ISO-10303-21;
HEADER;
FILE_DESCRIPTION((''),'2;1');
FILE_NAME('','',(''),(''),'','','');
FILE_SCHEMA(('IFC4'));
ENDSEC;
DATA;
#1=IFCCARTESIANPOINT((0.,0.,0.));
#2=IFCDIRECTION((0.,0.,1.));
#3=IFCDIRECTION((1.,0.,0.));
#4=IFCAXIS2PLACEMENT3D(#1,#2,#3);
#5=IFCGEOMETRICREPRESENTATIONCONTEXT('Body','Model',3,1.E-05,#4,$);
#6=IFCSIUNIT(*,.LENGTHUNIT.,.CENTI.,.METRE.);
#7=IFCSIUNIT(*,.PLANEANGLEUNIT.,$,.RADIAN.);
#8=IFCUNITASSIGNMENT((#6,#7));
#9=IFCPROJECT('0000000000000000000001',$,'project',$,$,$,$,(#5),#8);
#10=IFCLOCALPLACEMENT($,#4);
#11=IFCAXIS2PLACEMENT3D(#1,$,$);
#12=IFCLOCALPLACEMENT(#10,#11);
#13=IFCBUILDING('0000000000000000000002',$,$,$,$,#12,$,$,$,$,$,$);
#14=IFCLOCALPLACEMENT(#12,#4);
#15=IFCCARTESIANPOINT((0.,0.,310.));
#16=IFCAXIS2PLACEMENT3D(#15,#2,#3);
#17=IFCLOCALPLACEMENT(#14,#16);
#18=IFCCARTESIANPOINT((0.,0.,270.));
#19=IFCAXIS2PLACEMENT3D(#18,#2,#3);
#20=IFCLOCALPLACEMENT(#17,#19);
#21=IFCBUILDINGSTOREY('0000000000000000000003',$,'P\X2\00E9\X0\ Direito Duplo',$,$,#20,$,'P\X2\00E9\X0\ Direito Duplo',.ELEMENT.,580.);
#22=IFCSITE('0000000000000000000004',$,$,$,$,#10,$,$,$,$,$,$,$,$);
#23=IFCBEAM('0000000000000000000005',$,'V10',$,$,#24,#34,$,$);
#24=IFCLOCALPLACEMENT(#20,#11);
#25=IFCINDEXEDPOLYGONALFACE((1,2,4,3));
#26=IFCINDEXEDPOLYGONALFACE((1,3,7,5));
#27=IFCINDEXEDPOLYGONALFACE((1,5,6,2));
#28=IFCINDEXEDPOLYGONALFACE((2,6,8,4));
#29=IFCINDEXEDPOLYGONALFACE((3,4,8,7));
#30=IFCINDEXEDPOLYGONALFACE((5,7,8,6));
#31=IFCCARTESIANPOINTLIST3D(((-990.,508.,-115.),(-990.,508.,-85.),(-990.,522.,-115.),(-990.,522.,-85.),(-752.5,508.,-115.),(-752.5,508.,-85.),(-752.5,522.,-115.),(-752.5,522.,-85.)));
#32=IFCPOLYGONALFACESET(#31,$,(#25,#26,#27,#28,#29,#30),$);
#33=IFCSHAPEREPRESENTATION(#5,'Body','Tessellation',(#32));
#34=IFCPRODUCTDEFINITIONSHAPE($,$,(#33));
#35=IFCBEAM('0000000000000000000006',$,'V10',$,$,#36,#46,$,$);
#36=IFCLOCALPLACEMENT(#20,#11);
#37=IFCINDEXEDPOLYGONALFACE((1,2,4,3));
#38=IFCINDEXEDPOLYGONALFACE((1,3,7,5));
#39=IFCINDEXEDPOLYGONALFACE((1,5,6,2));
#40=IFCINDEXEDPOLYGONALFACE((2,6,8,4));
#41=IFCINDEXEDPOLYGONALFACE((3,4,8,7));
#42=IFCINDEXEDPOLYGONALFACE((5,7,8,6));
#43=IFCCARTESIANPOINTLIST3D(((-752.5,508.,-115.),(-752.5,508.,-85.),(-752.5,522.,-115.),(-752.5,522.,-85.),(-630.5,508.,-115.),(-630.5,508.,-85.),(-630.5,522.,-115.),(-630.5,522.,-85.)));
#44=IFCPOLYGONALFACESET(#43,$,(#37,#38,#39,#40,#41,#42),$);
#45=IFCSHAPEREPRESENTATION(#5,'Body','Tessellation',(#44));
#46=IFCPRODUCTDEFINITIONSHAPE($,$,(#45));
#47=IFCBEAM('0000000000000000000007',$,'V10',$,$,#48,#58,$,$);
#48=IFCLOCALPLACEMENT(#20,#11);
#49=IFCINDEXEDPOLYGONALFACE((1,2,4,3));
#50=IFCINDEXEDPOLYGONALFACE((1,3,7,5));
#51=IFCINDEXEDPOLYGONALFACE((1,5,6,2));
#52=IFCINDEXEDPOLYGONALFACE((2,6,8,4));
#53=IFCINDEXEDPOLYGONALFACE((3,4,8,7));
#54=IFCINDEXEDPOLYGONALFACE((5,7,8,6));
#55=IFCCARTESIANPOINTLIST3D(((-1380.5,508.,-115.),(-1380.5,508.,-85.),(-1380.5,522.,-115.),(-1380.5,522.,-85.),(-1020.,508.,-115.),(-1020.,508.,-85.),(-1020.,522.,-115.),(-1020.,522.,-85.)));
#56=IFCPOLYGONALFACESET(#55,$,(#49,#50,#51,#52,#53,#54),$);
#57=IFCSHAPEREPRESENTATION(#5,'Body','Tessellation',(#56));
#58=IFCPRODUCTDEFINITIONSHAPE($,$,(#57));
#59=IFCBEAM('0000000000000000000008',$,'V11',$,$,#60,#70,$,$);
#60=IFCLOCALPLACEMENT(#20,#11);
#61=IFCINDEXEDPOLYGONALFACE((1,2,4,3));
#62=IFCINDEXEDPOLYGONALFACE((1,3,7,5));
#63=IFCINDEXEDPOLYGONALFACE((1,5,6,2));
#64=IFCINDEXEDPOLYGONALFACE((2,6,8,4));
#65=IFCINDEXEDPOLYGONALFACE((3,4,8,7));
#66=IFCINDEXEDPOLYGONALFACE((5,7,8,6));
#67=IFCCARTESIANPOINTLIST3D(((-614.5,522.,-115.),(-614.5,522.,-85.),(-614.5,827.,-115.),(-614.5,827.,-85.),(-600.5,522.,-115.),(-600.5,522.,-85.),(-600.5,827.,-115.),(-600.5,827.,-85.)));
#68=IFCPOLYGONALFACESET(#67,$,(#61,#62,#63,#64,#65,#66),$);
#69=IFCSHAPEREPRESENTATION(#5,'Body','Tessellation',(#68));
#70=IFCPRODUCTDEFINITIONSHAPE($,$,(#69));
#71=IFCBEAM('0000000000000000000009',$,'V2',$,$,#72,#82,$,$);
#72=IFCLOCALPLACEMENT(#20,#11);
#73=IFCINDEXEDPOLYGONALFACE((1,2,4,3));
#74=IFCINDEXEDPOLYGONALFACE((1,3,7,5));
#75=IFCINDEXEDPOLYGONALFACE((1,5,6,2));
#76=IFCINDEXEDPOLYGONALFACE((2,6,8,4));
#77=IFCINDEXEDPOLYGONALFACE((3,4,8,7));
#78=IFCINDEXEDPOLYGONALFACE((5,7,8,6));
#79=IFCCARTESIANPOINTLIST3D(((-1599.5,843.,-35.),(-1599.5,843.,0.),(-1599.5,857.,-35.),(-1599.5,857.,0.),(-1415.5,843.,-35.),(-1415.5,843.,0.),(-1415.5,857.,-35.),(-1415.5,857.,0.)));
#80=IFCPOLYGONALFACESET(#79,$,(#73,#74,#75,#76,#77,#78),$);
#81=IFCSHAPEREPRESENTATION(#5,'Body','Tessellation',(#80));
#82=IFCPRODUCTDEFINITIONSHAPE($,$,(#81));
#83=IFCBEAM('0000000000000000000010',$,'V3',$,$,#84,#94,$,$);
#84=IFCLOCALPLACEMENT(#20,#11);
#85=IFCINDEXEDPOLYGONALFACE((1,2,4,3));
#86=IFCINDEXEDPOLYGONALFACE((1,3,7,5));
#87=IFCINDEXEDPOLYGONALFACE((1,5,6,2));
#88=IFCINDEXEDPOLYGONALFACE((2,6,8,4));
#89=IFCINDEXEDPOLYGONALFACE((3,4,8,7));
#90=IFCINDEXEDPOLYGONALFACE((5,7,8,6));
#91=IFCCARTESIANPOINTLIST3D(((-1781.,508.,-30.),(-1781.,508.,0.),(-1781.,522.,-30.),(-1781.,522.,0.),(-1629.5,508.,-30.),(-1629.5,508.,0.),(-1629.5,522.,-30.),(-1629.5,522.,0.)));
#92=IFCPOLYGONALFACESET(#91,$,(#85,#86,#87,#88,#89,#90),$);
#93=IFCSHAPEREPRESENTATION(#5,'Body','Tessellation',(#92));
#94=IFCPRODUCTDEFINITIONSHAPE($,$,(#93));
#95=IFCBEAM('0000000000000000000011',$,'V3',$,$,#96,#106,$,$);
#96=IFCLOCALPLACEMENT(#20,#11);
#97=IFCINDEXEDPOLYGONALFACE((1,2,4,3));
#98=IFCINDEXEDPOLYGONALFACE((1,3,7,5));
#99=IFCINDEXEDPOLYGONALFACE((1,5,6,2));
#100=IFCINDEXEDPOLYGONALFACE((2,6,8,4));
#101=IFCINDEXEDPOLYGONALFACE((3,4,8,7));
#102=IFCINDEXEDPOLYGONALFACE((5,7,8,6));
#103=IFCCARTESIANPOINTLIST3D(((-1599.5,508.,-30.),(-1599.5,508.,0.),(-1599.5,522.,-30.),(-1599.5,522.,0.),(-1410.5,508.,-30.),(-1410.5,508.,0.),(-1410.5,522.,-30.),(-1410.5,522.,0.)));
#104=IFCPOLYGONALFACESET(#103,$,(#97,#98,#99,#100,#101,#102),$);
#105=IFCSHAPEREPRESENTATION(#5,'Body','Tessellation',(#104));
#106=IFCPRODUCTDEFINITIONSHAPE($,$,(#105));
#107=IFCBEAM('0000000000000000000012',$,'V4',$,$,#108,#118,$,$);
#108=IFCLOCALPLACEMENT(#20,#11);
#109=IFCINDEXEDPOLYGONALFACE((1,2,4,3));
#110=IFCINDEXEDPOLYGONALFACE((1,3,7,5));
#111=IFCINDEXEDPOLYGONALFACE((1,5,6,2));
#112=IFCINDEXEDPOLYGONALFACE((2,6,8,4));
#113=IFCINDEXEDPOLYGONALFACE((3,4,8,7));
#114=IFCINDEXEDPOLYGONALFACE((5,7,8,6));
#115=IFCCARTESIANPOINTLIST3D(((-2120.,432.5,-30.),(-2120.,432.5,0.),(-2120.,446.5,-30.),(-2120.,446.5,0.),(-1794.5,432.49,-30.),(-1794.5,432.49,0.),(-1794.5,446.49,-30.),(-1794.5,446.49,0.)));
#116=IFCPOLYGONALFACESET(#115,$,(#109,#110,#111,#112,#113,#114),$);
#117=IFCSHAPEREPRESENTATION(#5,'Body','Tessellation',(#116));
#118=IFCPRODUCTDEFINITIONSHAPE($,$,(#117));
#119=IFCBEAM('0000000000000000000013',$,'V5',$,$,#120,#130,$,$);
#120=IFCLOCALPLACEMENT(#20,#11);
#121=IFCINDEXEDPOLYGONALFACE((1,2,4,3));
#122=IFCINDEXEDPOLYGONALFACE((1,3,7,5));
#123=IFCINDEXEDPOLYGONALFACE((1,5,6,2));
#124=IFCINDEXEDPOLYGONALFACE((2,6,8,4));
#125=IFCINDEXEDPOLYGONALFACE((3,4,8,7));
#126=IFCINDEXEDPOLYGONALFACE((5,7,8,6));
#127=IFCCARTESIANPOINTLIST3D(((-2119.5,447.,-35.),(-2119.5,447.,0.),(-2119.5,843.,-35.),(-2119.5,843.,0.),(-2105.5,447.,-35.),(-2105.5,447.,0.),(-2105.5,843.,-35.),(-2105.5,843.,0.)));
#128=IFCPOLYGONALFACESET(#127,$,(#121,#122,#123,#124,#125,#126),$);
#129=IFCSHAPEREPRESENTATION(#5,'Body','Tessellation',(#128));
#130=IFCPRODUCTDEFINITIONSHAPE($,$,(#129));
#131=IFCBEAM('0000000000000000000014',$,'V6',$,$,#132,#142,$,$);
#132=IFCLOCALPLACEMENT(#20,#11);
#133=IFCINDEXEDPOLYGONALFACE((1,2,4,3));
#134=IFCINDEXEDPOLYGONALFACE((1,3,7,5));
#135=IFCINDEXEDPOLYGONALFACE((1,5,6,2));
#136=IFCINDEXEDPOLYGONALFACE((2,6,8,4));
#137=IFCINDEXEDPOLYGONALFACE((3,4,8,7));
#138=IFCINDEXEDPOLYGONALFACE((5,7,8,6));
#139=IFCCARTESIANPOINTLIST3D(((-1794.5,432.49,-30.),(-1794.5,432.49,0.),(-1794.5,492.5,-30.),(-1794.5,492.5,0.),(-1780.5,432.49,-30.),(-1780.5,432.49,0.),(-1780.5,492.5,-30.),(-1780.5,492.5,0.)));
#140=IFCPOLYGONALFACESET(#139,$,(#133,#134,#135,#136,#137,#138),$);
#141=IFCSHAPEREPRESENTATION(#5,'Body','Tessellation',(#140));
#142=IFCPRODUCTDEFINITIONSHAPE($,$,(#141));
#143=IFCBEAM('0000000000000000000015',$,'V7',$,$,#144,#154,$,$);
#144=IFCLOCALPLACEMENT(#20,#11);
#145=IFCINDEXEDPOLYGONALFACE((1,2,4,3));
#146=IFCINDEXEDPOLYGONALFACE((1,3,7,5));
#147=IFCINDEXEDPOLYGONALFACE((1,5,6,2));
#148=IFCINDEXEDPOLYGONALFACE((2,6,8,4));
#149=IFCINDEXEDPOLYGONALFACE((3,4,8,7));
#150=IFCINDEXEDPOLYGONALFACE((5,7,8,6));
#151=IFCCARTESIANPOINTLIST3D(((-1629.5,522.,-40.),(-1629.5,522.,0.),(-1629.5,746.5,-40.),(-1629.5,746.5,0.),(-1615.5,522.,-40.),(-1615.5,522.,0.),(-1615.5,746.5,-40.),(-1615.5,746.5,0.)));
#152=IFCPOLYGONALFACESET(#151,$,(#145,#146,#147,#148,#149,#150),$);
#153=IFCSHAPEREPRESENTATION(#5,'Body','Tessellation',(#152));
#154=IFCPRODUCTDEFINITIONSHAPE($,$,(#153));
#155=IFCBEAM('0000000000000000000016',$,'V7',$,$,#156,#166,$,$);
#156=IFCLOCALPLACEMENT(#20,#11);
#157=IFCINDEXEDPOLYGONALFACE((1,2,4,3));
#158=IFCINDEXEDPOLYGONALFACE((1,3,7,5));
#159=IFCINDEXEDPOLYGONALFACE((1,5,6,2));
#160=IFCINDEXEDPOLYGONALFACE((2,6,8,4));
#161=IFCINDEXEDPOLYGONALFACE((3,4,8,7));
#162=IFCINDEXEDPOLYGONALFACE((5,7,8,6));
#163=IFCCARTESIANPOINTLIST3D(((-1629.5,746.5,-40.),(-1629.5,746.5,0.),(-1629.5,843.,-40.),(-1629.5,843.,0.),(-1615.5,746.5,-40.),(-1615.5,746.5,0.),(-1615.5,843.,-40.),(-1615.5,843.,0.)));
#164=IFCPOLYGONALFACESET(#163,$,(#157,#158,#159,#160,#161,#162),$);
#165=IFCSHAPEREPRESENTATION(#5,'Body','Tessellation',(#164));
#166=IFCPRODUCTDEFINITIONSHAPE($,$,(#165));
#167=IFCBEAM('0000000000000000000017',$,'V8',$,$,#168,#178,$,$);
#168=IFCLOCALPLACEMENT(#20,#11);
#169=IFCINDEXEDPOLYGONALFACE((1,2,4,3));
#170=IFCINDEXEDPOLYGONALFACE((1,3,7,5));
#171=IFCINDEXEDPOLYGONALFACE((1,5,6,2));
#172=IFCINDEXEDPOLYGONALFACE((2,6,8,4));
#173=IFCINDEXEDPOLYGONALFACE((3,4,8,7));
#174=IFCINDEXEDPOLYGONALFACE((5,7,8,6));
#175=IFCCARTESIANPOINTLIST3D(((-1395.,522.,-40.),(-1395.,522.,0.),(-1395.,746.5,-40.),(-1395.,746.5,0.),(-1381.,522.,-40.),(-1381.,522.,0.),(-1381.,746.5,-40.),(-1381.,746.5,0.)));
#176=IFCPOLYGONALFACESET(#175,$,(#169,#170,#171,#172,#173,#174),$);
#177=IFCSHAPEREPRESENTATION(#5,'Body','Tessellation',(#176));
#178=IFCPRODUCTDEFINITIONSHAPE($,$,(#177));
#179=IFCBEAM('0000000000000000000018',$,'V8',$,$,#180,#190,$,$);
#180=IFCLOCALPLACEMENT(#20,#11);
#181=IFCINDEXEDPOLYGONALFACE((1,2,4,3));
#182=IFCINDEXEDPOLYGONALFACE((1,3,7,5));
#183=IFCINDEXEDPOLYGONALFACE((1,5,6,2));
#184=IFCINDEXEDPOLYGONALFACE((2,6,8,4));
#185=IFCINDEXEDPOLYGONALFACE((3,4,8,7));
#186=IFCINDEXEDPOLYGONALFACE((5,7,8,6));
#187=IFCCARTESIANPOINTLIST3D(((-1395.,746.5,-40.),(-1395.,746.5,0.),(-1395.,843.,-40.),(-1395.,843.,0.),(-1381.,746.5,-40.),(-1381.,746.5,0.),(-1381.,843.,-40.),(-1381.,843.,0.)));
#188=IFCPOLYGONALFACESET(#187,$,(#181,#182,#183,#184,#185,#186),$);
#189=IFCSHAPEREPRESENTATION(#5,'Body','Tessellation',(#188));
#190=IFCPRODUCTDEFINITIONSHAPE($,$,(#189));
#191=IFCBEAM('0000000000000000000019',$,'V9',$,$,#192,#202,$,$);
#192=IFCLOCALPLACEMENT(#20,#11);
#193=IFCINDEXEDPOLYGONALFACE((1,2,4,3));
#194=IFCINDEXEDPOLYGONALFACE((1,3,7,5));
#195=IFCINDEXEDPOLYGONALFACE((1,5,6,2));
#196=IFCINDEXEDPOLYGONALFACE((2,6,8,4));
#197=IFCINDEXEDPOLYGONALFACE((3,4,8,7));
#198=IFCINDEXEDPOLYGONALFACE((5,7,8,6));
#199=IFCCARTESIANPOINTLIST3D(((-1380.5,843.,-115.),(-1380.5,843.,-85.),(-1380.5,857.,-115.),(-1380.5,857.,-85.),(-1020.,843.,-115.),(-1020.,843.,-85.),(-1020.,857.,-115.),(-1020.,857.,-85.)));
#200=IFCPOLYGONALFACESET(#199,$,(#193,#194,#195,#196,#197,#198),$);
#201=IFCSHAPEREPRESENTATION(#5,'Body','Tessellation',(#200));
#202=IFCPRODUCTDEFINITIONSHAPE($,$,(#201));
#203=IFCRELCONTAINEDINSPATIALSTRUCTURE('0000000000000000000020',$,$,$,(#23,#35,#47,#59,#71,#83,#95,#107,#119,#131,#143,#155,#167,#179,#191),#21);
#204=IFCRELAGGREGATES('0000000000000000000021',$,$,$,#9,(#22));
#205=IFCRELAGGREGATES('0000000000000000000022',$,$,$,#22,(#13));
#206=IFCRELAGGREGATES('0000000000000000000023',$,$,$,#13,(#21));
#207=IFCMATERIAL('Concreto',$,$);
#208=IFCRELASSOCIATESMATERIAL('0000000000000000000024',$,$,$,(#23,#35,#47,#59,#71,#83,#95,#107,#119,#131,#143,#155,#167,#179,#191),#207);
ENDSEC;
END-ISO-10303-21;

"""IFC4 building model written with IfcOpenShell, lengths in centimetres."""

from ifc_helpers import new_model, si_unit, frame, origin, origin_with_axes, origin_2d_with_axis, place, context, project, spatial, rectangle, extrude, material, element, save


model = new_model("IFC4")

# Units and contexts
model_context = context("Model", 3, precision=1e-05, world=origin_with_axes(), identifier="Body")
ifc_project = project(units=[si_unit("LENGTHUNIT", "METRE", prefix="CENTI"), si_unit("PLANEANGLEUNIT", "RADIAN")], contexts=[model_context])

# Site, building, storey
site_placement = place(None, origin_with_axes())
site = spatial("IfcSite", under=ifc_project, at=site_placement)
building_placement = place(site_placement, origin())
building = spatial("IfcBuilding", under=site, at=building_placement)
placement_1 = place(building_placement, origin_with_axes())
placement_2 = place(placement_1, frame((0.0, 0.0, 310.0), z_axis=(0.0, 0.0, 1.0), x_axis=(1.0, 0.0, 0.0)))
storey_placement = place(placement_2, frame((0.0, 0.0, 270.0), z_axis=(0.0, 0.0, 1.0), x_axis=(1.0, 0.0, 0.0)))
storey = spatial("IfcBuildingStorey", under=building, at=storey_placement, Name="Pé Direito Duplo", LongName="Pé Direito Duplo", CompositionType="ELEMENT", Elevation=580.0)

# Shared definitions
ifc_material = material(Name="Concreto")

# Beams
beam_1_placement = place(storey_placement, frame((-871.25, 515.0, -85.0), z_axis=(0.0, 0.0, 1.0), x_axis=(1.0, 0.0, 0.0)))
element("IfcBeam", 1, at=beam_1_placement, inside=storey, material=ifc_material, Name="V10", context=model_context, shape_type="SolidModel", body=[
    extrude(rectangle(XDim=14.0, YDim=30.0, at=origin_2d_with_axis()), frame((-118.75, 0.0, -15.0), z_axis=(1.0, 0.0, 0.0), x_axis=(0.0, -1.0, 0.0)), (0.0, 0.0, 1.0), 237.5),
])
beam_2_placement = place(storey_placement, frame((-691.5, 515.0, -85.0), z_axis=(0.0, 0.0, 1.0), x_axis=(1.0, 0.0, 0.0)))
element("IfcBeam", 2, at=beam_2_placement, inside=storey, material=ifc_material, Name="V10", context=model_context, shape_type="SolidModel", body=[
    extrude(rectangle(XDim=14.0, YDim=30.0, at=origin_2d_with_axis()), frame((-61.0, 0.0, -15.0), z_axis=(1.0, 0.0, 0.0), x_axis=(0.0, 1.0, 0.0)), (0.0, 0.0, 1.0), 122.0),
])
beam_3_placement = place(storey_placement, frame((-1200.25, 515.0, -85.0), z_axis=(0.0, 0.0, 1.0), x_axis=(1.0, 0.0, 0.0)))
element("IfcBeam", 3, at=beam_3_placement, inside=storey, material=ifc_material, Name="V10", context=model_context, shape_type="SolidModel", body=[
    extrude(rectangle(XDim=14.0, YDim=30.0, at=origin_2d_with_axis()), frame((-180.25, 0.0, -15.0), z_axis=(1.0, 0.0, 0.0), x_axis=(0.0, -1.0, 0.0)), (0.0, 0.0, 1.0), 360.5),
])
beam_4_placement = place(storey_placement, frame((-607.5, 674.5, -85.0), z_axis=(0.0, 0.0, 1.0), x_axis=(1.0, 0.0, 0.0)))
element("IfcBeam", 4, at=beam_4_placement, inside=storey, material=ifc_material, Name="V11", context=model_context, shape_type="SolidModel", body=[
    extrude(rectangle(XDim=14.0, YDim=30.0, at=origin_2d_with_axis()), frame((0.0, -152.5, -15.0), z_axis=(0.0, 1.0, 0.0), x_axis=(-1.0, 0.0, 0.0)), (0.0, 0.0, 1.0), 305.0),
])
beam_5_placement = place(storey_placement, frame((-1507.5, 850.0, 0.0), z_axis=(0.0, 0.0, 1.0), x_axis=(1.0, 0.0, 0.0)))
element("IfcBeam", 5, at=beam_5_placement, inside=storey, material=ifc_material, Name="V2", context=model_context, shape_type="SolidModel", body=[
    extrude(rectangle(XDim=14.0, YDim=35.0, at=origin_2d_with_axis()), frame((-92.0, 0.0, -17.5), z_axis=(1.0, 0.0, 0.0), x_axis=(0.0, -1.0, 0.0)), (0.0, 0.0, 1.0), 184.0),
])
beam_6_placement = place(storey_placement, frame((-1705.25, 515.0, 0.0), z_axis=(0.0, 0.0, 1.0), x_axis=(1.0, 0.0, 0.0)))
element("IfcBeam", 6, at=beam_6_placement, inside=storey, material=ifc_material, Name="V3", context=model_context, shape_type="SolidModel", body=[
    extrude(rectangle(XDim=14.0, YDim=30.0, at=origin_2d_with_axis()), frame((-75.75, 0.0, -15.0), z_axis=(1.0, 0.0, 0.0), x_axis=(0.0, -1.0, 0.0)), (0.0, 0.0, 1.0), 151.5),
])
beam_7_placement = place(storey_placement, frame((-1505.0, 515.0, 0.0), z_axis=(0.0, 0.0, 1.0), x_axis=(1.0, 0.0, 0.0)))
element("IfcBeam", 7, at=beam_7_placement, inside=storey, material=ifc_material, Name="V3", context=model_context, shape_type="SolidModel", body=[
    extrude(rectangle(XDim=14.0, YDim=30.0, at=origin_2d_with_axis()), frame((-94.5, 0.0, -15.0), z_axis=(1.0, 0.0, 0.0), x_axis=(0.0, -1.0, 0.0)), (0.0, 0.0, 1.0), 189.0),
])
beam_8_placement = place(storey_placement, frame((-1957.25, 439.5, 0.0), z_axis=(0.0, 0.0, 1.0), x_axis=(1.0, 0.0, 0.0)))
element("IfcBeam", 8, at=beam_8_placement, inside=storey, material=ifc_material, Name="V4", context=model_context, shape_type="SolidModel", body=[
    extrude(rectangle(XDim=14.0, YDim=30.0, at=origin_2d_with_axis()), frame((-162.75, 0.01, -15.0), z_axis=(1.0, -0.000033, 0.0), x_axis=(-0.000033, -1.0, 0.0)), (0.0, 0.0, 1.0), 325.5),
])
beam_9_placement = place(storey_placement, frame((-2112.5, 645.0, 0.0), z_axis=(0.0, 0.0, 1.0), x_axis=(1.0, 0.0, 0.0)))
element("IfcBeam", 9, at=beam_9_placement, inside=storey, material=ifc_material, Name="V5", context=model_context, shape_type="SolidModel", body=[
    extrude(rectangle(XDim=14.0, YDim=35.0, at=origin_2d_with_axis()), frame((0.0, -198.0, -17.5), z_axis=(0.0, 1.0, 0.0), x_axis=(-1.0, 0.0, 0.0)), (0.0, 0.0, 1.0), 396.0),
])
beam_10_placement = place(storey_placement, frame((-1787.5, 462.5, 0.0), z_axis=(0.0, 0.0, 1.0), x_axis=(1.0, 0.0, 0.0)))
element("IfcBeam", 10, at=beam_10_placement, inside=storey, material=ifc_material, Name="V6", context=model_context, shape_type="SolidModel", body=[
    extrude(rectangle(XDim=14.0, YDim=30.0, at=origin_2d_with_axis()), frame((0.0, -30.0, -15.0), z_axis=(0.0, 1.0, 0.0), x_axis=(-1.0, 0.0, 0.0)), (0.0, 0.0, 1.0), 60.01),
])
beam_11_placement = place(storey_placement, frame((-1622.5, 634.25, 0.0), z_axis=(0.0, 0.0, 1.0), x_axis=(1.0, 0.0, 0.0)))
element("IfcBeam", 11, at=beam_11_placement, inside=storey, material=ifc_material, Name="V7", context=model_context, shape_type="SolidModel", body=[
    extrude(rectangle(XDim=14.0, YDim=40.0, at=origin_2d_with_axis()), frame((0.0, -112.25, -20.0), z_axis=(0.0, 1.0, 0.0), x_axis=(-1.0, 0.0, 0.0)), (0.0, 0.0, 1.0), 224.5),
])
beam_12_placement = place(storey_placement, frame((-1622.5, 794.75, 0.0), z_axis=(0.0, 0.0, 1.0), x_axis=(1.0, 0.0, 0.0)))
element("IfcBeam", 12, at=beam_12_placement, inside=storey, material=ifc_material, Name="V7", context=model_context, shape_type="SolidModel", body=[
    extrude(rectangle(XDim=14.0, YDim=40.0, at=origin_2d_with_axis()), frame((0.0, -48.25, -20.0), z_axis=(0.0, 1.0, 0.0), x_axis=(-1.0, 0.0, 0.0)), (0.0, 0.0, 1.0), 96.5),
])
beam_13_placement = place(storey_placement, frame((-1388.0, 634.25, 0.0), z_axis=(0.0, 0.0, 1.0), x_axis=(1.0, 0.0, 0.0)))
element("IfcBeam", 13, at=beam_13_placement, inside=storey, material=ifc_material, Name="V8", context=model_context, shape_type="SolidModel", body=[
    extrude(rectangle(XDim=14.0, YDim=40.0, at=origin_2d_with_axis()), frame((0.0, -112.25, -20.0), z_axis=(0.0, 1.0, 0.0), x_axis=(-1.0, 0.0, 0.0)), (0.0, 0.0, 1.0), 224.5),
])
beam_14_placement = place(storey_placement, frame((-1388.0, 794.75, 0.0), z_axis=(0.0, 0.0, 1.0), x_axis=(1.0, 0.0, 0.0)))
element("IfcBeam", 14, at=beam_14_placement, inside=storey, material=ifc_material, Name="V8", context=model_context, shape_type="SolidModel", body=[
    extrude(rectangle(XDim=14.0, YDim=40.0, at=origin_2d_with_axis()), frame((0.0, -48.25, -20.0), z_axis=(0.0, 1.0, 0.0), x_axis=(-1.0, 0.0, 0.0)), (0.0, 0.0, 1.0), 96.5),
])
beam_15_placement = place(storey_placement, frame((-1200.25, 850.0, -85.0), z_axis=(0.0, 0.0, 1.0), x_axis=(1.0, 0.0, 0.0)))
element("IfcBeam", 15, at=beam_15_placement, inside=storey, material=ifc_material, Name="V9", context=model_context, shape_type="SolidModel", body=[
    extrude(rectangle(XDim=14.0, YDim=30.0, at=origin_2d_with_axis()), frame((-180.25, 0.0, -15.0), z_axis=(1.0, 0.0, 0.0), x_axis=(0.0, -1.0, 0.0)), (0.0, 0.0, 1.0), 360.5),
])

save(model, "model.ifc")
